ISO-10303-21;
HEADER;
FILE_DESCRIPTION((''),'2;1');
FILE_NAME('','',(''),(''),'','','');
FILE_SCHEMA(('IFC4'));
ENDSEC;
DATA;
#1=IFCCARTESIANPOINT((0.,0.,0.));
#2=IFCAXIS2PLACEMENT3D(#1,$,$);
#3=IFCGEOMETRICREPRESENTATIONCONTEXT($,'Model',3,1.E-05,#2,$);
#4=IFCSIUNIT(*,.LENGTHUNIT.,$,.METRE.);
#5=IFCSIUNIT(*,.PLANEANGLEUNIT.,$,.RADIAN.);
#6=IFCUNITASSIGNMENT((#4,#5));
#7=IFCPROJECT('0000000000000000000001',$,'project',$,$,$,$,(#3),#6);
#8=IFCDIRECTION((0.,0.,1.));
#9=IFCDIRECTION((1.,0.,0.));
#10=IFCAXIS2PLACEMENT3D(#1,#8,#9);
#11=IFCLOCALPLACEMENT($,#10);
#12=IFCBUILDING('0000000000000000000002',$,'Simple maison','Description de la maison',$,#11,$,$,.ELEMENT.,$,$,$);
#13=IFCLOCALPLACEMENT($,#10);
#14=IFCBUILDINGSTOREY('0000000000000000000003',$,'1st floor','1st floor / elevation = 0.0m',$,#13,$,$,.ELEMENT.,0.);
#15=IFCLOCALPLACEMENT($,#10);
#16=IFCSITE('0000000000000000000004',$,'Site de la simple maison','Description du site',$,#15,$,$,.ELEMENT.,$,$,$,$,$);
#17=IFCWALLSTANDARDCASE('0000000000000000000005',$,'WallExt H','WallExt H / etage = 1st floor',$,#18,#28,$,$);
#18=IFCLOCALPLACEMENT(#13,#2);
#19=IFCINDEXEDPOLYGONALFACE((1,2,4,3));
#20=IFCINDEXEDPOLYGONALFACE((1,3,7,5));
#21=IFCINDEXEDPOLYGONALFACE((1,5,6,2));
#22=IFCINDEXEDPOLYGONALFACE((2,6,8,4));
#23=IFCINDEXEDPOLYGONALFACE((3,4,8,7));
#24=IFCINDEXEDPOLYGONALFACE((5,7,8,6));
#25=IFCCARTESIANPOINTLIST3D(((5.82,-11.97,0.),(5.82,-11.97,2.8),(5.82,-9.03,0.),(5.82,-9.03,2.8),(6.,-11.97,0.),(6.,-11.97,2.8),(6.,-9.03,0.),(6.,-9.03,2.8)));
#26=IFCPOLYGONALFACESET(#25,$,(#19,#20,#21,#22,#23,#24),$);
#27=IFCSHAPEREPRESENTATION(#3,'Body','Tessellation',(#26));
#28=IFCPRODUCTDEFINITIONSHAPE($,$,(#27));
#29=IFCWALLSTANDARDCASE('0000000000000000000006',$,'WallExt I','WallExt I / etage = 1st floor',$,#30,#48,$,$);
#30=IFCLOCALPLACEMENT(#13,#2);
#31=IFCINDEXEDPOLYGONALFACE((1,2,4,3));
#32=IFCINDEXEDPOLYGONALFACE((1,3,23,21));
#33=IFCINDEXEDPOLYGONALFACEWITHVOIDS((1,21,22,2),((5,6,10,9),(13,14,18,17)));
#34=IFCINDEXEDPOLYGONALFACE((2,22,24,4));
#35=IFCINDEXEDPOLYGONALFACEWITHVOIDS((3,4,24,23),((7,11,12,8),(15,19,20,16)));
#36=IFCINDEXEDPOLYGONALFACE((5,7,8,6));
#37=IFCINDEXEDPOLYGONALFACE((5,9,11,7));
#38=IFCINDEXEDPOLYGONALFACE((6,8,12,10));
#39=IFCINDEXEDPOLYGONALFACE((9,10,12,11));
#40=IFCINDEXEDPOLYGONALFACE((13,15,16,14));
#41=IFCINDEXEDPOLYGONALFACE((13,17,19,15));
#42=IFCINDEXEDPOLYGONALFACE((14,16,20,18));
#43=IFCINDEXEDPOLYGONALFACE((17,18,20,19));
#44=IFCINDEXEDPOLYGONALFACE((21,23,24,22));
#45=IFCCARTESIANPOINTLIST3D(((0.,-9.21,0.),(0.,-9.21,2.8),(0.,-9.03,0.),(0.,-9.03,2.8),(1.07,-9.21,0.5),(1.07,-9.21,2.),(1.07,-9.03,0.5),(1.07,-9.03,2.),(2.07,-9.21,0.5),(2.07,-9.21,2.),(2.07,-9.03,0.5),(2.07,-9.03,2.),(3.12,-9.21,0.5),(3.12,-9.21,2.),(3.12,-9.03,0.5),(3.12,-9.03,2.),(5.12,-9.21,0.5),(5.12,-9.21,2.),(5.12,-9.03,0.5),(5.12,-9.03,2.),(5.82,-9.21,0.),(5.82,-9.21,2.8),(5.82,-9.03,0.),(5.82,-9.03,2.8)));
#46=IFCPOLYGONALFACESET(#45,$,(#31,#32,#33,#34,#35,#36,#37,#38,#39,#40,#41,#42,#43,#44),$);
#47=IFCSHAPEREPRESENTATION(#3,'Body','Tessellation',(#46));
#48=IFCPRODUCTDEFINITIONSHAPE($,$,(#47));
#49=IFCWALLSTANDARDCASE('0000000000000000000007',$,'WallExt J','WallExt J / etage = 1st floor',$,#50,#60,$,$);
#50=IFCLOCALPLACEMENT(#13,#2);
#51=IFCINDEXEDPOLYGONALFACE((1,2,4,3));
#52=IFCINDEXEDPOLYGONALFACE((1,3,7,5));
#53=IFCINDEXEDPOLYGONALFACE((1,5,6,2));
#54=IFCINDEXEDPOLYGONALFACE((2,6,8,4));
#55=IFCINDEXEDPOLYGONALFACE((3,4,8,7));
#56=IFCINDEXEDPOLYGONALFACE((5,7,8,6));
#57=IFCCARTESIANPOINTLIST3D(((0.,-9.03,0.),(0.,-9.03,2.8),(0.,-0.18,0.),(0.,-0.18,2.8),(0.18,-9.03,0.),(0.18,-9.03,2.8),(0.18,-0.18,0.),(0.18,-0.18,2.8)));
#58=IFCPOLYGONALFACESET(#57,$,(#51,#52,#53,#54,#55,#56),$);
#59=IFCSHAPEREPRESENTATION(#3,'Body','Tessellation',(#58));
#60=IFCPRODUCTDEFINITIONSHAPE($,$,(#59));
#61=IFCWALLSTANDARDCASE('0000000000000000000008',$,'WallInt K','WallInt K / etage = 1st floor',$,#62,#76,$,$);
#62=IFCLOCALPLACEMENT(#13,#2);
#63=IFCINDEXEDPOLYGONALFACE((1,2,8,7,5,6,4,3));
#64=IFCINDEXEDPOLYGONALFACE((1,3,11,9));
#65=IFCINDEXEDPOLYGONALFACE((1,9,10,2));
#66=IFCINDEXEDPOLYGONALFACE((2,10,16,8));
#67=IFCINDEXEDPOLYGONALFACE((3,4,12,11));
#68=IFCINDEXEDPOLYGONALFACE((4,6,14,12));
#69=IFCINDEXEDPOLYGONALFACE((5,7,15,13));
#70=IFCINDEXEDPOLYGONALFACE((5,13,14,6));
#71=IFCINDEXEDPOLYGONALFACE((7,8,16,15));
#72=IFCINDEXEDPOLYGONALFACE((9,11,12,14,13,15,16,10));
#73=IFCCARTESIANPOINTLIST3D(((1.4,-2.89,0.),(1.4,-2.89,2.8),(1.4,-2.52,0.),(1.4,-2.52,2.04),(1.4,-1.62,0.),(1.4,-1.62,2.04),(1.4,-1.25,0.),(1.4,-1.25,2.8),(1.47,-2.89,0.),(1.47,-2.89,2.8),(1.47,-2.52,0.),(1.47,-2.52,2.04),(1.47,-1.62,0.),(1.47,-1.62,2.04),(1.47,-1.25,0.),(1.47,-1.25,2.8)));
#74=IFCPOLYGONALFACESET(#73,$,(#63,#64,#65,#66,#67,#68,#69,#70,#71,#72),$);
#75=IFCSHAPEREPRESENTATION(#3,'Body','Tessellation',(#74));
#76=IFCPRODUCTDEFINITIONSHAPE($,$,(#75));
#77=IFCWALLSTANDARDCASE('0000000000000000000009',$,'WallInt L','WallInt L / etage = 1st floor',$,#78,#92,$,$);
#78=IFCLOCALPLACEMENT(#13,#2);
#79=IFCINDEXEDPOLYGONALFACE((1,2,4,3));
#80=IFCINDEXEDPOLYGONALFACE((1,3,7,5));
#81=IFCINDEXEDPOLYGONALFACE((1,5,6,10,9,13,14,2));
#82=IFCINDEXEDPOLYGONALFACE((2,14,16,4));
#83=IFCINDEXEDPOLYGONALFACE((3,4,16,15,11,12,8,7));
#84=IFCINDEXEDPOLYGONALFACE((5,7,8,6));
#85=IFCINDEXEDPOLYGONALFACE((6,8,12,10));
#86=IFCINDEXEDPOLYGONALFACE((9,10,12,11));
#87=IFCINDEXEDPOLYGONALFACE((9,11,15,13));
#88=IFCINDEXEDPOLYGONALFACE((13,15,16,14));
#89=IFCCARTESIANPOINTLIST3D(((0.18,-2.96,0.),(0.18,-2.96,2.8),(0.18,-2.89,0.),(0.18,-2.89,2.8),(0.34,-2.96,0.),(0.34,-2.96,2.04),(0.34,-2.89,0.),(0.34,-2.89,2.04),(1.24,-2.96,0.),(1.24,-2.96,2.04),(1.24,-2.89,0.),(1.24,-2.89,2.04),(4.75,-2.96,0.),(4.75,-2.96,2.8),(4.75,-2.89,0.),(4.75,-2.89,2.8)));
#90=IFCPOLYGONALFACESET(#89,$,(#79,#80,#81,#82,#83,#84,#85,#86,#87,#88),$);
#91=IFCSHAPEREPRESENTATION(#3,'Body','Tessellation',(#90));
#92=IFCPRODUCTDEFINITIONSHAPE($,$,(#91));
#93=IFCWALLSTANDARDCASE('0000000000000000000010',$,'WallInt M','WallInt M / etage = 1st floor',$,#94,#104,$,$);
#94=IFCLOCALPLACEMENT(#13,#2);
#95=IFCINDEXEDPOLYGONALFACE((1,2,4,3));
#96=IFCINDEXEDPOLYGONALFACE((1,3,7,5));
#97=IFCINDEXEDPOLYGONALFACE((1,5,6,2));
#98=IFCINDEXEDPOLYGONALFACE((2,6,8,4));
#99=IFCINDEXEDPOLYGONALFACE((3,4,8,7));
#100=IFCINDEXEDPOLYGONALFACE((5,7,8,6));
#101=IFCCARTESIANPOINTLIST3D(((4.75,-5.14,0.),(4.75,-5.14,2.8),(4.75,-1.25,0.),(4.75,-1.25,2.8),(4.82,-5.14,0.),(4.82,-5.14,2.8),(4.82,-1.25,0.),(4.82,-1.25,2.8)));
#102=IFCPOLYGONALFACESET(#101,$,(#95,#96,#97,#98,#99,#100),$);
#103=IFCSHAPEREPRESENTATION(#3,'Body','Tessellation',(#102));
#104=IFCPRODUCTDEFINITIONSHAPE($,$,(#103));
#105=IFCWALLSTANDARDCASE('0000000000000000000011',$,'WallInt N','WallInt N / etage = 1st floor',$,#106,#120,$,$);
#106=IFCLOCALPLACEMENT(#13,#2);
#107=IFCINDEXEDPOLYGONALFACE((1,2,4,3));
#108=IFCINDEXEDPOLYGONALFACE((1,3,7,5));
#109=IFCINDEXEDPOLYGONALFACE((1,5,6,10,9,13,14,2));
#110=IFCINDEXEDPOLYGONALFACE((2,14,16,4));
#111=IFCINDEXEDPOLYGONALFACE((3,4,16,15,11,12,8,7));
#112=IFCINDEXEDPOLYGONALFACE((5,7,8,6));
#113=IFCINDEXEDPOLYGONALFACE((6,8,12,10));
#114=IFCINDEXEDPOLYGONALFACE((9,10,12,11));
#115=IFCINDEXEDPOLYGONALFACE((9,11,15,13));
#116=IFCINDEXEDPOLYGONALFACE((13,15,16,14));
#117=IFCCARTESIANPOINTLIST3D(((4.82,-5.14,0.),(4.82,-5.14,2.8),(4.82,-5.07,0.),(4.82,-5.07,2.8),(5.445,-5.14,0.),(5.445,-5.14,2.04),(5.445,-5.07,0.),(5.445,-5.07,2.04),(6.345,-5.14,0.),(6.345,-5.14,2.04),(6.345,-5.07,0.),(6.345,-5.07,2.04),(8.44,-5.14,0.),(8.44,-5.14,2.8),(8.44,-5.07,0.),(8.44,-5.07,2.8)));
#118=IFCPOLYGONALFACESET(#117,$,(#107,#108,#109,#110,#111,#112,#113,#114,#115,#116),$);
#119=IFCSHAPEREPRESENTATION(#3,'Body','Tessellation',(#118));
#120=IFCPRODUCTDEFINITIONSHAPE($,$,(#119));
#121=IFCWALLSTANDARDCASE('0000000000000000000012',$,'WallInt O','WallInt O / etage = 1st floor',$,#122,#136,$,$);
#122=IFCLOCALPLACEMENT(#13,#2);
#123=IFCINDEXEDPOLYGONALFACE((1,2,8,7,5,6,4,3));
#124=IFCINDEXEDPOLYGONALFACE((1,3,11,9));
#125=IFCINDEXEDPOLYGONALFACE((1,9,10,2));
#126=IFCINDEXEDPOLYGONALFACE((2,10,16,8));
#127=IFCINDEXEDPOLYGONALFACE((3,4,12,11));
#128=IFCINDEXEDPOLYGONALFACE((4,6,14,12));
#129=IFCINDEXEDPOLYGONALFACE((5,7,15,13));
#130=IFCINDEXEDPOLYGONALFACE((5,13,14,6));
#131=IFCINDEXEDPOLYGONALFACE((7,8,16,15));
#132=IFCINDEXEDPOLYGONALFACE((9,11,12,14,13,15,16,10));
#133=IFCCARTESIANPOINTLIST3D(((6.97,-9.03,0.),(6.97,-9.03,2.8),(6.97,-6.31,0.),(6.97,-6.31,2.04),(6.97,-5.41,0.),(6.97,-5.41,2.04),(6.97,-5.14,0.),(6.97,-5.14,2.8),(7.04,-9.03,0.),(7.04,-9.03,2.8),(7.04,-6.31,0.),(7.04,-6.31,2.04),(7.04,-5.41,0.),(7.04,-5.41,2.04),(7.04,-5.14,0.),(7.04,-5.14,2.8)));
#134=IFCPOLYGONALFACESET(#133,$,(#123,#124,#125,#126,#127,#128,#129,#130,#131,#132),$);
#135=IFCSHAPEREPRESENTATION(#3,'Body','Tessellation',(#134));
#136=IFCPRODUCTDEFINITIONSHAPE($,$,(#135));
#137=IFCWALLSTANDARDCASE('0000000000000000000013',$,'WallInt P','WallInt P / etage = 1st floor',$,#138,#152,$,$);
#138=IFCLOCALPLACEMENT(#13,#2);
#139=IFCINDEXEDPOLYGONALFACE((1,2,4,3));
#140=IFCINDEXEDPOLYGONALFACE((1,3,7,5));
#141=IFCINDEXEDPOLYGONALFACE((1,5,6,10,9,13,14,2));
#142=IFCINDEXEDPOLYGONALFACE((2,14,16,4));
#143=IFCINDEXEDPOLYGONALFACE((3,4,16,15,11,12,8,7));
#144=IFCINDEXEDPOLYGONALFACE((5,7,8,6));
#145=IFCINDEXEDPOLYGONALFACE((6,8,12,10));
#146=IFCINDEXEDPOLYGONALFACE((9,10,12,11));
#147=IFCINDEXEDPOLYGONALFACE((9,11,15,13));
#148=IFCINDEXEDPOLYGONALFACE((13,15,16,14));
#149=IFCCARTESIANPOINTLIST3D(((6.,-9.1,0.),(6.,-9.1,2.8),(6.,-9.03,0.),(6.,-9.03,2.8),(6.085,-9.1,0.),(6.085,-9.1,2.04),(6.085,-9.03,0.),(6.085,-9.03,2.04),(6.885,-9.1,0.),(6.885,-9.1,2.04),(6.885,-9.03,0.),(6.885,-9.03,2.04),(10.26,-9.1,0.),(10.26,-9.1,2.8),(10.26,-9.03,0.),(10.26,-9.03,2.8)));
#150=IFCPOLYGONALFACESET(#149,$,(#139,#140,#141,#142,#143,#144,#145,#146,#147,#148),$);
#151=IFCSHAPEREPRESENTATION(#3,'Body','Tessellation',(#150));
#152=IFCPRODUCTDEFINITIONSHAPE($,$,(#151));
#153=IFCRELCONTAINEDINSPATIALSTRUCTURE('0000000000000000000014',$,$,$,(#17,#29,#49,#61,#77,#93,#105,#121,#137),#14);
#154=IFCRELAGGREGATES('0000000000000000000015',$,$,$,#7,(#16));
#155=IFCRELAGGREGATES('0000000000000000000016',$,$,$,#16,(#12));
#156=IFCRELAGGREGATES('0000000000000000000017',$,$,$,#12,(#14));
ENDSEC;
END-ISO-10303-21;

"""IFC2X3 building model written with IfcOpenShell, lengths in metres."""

from ifc_helpers import new_model, si_unit, frame, origin, origin_with_axes, origin_2d_with_axis, place, context, project, spatial, polyline, rectangle, outline, extrude, element, save


model = new_model("IFC2X3")

# Units and contexts
model_context = context("Model", 3, precision=1e-05, world=origin())
ifc_project = project(units=[si_unit("LENGTHUNIT", "METRE"), si_unit("PLANEANGLEUNIT", "RADIAN")], contexts=[model_context])

# Site, building, storey
site_placement = place(None, origin_with_axes())
site = spatial("IfcSite", under=ifc_project, at=site_placement, Name="Site de la simple maison", Description="Description du site", CompositionType="ELEMENT")
building_placement = place(None, origin_with_axes())
building = spatial("IfcBuilding", under=site, at=building_placement, Name="Simple maison", Description="Description de la maison", CompositionType="ELEMENT")
storey_placement = place(None, origin_with_axes())
storey = spatial("IfcBuildingStorey", under=building, at=storey_placement, Name="1st floor", Description="1st floor / elevation = 0.0m", CompositionType="ELEMENT", Elevation=0.0)

# Wall
wall_1_placement = place(storey_placement, frame((5.91, -11.97, 0.0), z_axis=(0.0, 0.0, 1.0), x_axis=(0.0, 1.0, 0.0)))
element("IfcWallStandardCase", 1, at=wall_1_placement, inside=storey, Name="WallExt H", Description="WallExt H / etage = 1st floor", context=model_context, shape_type="SweptSolid", body=[
    extrude(outline(polyline([(0.0, 0.09), (2.94, 0.09), (2.94, -0.09), (0.0, -0.09), (0.0, 0.09)])), origin(), (0.0, 0.0, 1.0), 2.8),
])

# Wall, openings
wall_2_placement = place(storey_placement, frame((5.82, -9.12, 0.0), z_axis=(0.0, 0.0, 1.0), x_axis=(-1.0, 0.0, 0.0)))
wall_2 = element("IfcWallStandardCase", 2, at=wall_2_placement, inside=storey, Name="WallExt I", Description="WallExt I / etage = 1st floor", context=model_context, shape_type="SweptSolid", body=[
    extrude(outline(polyline([(0.0, 0.09), (5.82, 0.09), (5.82, -0.09), (0.0, -0.09), (0.0, 0.09)])), origin(), (0.0, 0.0, 1.0), 2.8),
])
opening_1_placement = place(wall_2_placement, frame((3.75, -0.09, 0.5), z_axis=(0.0, 0.0, 1.0), x_axis=(1.0, 0.0, 0.0)))
element("IfcOpeningElement", 3, at=opening_1_placement, cuts=wall_2, context=model_context, shape_type="SweptSolid", body=[
    extrude(rectangle(XDim=1.5, YDim=1.0, at=origin_2d_with_axis()), frame((0.5, 0.0, 0.75), z_axis=(0.0, 1.0, 0.0), x_axis=(0.0, 0.0, 1.0)), (0.0, 0.0, 1.0), 0.18),
])
opening_2_placement = place(wall_2_placement, frame((0.7, -0.09, 0.5), z_axis=(0.0, 0.0, 1.0), x_axis=(1.0, 0.0, 0.0)))
element("IfcOpeningElement", 4, at=opening_2_placement, cuts=wall_2, context=model_context, shape_type="SweptSolid", body=[
    extrude(rectangle(XDim=1.5, YDim=2.0, at=origin_2d_with_axis()), frame((1.0, 0.0, 0.75), z_axis=(0.0, 1.0, 0.0), x_axis=(0.0, 0.0, 1.0)), (0.0, 0.0, 1.0), 0.18),
])

# Wall
wall_3_placement = place(storey_placement, frame((0.09, -9.03, 0.0), z_axis=(0.0, 0.0, 1.0), x_axis=(0.0, 1.0, 0.0)))
element("IfcWallStandardCase", 5, at=wall_3_placement, inside=storey, Name="WallExt J", Description="WallExt J / etage = 1st floor", context=model_context, shape_type="SweptSolid", body=[
    extrude(outline(polyline([(0.0, 0.09), (8.85, 0.09), (8.85, -0.09), (0.0, -0.09), (0.0, 0.09)])), origin(), (0.0, 0.0, 1.0), 2.8),
])

# Walls, openings
wall_4_placement = place(storey_placement, frame((1.435, -1.25, 0.0), z_axis=(0.0, 0.0, 1.0), x_axis=(0.0, -1.0, 0.0)))
wall_4 = element("IfcWallStandardCase", 6, at=wall_4_placement, inside=storey, Name="WallInt K", Description="WallInt K / etage = 1st floor", context=model_context, shape_type="SweptSolid", body=[
    extrude(outline(polyline([(0.0, 0.035), (1.64, 0.035), (1.64, -0.035), (0.0, -0.035), (0.0, 0.035)])), origin(), (0.0, 0.0, 1.0), 2.8),
])
opening_3_placement = place(wall_4_placement, frame((0.37, -0.035, 0.0), z_axis=(0.0, 0.0, 1.0), x_axis=(1.0, 0.0, 0.0)))
element("IfcOpeningElement", 7, at=opening_3_placement, cuts=wall_4, context=model_context, shape_type="SweptSolid", body=[
    extrude(rectangle(XDim=2.04, YDim=0.9, at=origin_2d_with_axis()), frame((0.45, 0.0, 1.02), z_axis=(0.0, 1.0, 0.0), x_axis=(0.0, 0.0, 1.0)), (0.0, 0.0, 1.0), 0.07),
])
wall_5_placement = place(storey_placement, frame((0.18, -2.925, 0.0), z_axis=(0.0, 0.0, 1.0), x_axis=(1.0, 0.0, 0.0)))
wall_5 = element("IfcWallStandardCase", 8, at=wall_5_placement, inside=storey, Name="WallInt L", Description="WallInt L / etage = 1st floor", context=model_context, shape_type="SweptSolid", body=[
    extrude(outline(polyline([(0.0, 0.035), (4.57, 0.035), (4.57, -0.035), (0.0, -0.035), (0.0, 0.035)])), origin(), (0.0, 0.0, 1.0), 2.8),
])
opening_4_placement = place(wall_5_placement, frame((0.16, -0.035, 0.0), z_axis=(0.0, 0.0, 1.0), x_axis=(1.0, 0.0, 0.0)))
element("IfcOpeningElement", 9, at=opening_4_placement, cuts=wall_5, context=model_context, shape_type="SweptSolid", body=[
    extrude(rectangle(XDim=2.04, YDim=0.9, at=origin_2d_with_axis()), frame((0.45, 0.0, 1.02), z_axis=(0.0, 1.0, 0.0), x_axis=(0.0, 0.0, 1.0)), (0.0, 0.0, 1.0), 0.07),
])

# Wall
wall_6_placement = place(storey_placement, frame((4.785, -1.25, 0.0), z_axis=(0.0, 0.0, 1.0), x_axis=(0.0, -1.0, 0.0)))
element("IfcWallStandardCase", 10, at=wall_6_placement, inside=storey, Name="WallInt M", Description="WallInt M / etage = 1st floor", context=model_context, shape_type="SweptSolid", body=[
    extrude(outline(polyline([(0.0, 0.035), (3.89, 0.035), (3.89, -0.035), (0.0, -0.035), (0.0, 0.035)])), origin(), (0.0, 0.0, 1.0), 2.8),
])

# Walls, openings
wall_7_placement = place(storey_placement, frame((4.82, -5.105, 0.0), z_axis=(0.0, 0.0, 1.0), x_axis=(1.0, 0.0, 0.0)))
wall_7 = element("IfcWallStandardCase", 11, at=wall_7_placement, inside=storey, Name="WallInt N", Description="WallInt N / etage = 1st floor", context=model_context, shape_type="SweptSolid", body=[
    extrude(outline(polyline([(0.0, 0.035), (3.62, 0.035), (3.62, -0.035), (0.0, -0.035), (0.0, 0.035)])), origin(), (0.0, 0.0, 1.0), 2.8),
])
opening_5_placement = place(wall_7_placement, frame((0.625, -0.035, 0.0), z_axis=(0.0, 0.0, 1.0), x_axis=(1.0, 0.0, 0.0)))
element("IfcOpeningElement", 12, at=opening_5_placement, cuts=wall_7, context=model_context, shape_type="SweptSolid", body=[
    extrude(rectangle(XDim=2.04, YDim=0.9, at=origin_2d_with_axis()), frame((0.45, 0.0, 1.02), z_axis=(0.0, 1.0, 0.0), x_axis=(0.0, 0.0, 1.0)), (0.0, 0.0, 1.0), 0.07),
])
wall_8_placement = place(storey_placement, frame((7.005, -5.14, 0.0), z_axis=(0.0, 0.0, 1.0), x_axis=(0.0, -1.0, 0.0)))
wall_8 = element("IfcWallStandardCase", 13, at=wall_8_placement, inside=storey, Name="WallInt O", Description="WallInt O / etage = 1st floor", context=model_context, shape_type="SweptSolid", body=[
    extrude(outline(polyline([(0.0, 0.035), (3.89, 0.035), (3.89, -0.035), (0.0, -0.035), (0.0, 0.035)])), origin(), (0.0, 0.0, 1.0), 2.8),
])
opening_6_placement = place(wall_8_placement, frame((0.27, -0.035, 0.0), z_axis=(0.0, 0.0, 1.0), x_axis=(1.0, 0.0, 0.0)))
element("IfcOpeningElement", 14, at=opening_6_placement, cuts=wall_8, context=model_context, shape_type="SweptSolid", body=[
    extrude(rectangle(XDim=2.04, YDim=0.9, at=origin_2d_with_axis()), frame((0.45, 0.0, 1.02), z_axis=(0.0, 1.0, 0.0), x_axis=(0.0, 0.0, 1.0)), (0.0, 0.0, 1.0), 0.07),
])
wall_9_placement = place(storey_placement, frame((6.0, -9.065, 0.0), z_axis=(0.0, 0.0, 1.0), x_axis=(1.0, 0.0, 0.0)))
wall_9 = element("IfcWallStandardCase", 15, at=wall_9_placement, inside=storey, Name="WallInt P", Description="WallInt P / etage = 1st floor", context=model_context, shape_type="SweptSolid", body=[
    extrude(outline(polyline([(0.0, 0.035), (4.26, 0.035), (4.26, -0.035), (0.0, -0.035), (0.0, 0.035)])), origin(), (0.0, 0.0, 1.0), 2.8),
])
opening_7_placement = place(wall_9_placement, frame((0.085, -0.035, 0.0), z_axis=(0.0, 0.0, 1.0), x_axis=(1.0, 0.0, 0.0)))
element("IfcOpeningElement", 16, at=opening_7_placement, cuts=wall_9, context=model_context, shape_type="SweptSolid", body=[
    extrude(rectangle(XDim=2.04, YDim=0.8, at=origin_2d_with_axis()), frame((0.4, 0.0, 1.02), z_axis=(0.0, 1.0, 0.0), x_axis=(0.0, 0.0, 1.0)), (0.0, 0.0, 1.0), 0.07),
])

save(model, "model.ifc")
